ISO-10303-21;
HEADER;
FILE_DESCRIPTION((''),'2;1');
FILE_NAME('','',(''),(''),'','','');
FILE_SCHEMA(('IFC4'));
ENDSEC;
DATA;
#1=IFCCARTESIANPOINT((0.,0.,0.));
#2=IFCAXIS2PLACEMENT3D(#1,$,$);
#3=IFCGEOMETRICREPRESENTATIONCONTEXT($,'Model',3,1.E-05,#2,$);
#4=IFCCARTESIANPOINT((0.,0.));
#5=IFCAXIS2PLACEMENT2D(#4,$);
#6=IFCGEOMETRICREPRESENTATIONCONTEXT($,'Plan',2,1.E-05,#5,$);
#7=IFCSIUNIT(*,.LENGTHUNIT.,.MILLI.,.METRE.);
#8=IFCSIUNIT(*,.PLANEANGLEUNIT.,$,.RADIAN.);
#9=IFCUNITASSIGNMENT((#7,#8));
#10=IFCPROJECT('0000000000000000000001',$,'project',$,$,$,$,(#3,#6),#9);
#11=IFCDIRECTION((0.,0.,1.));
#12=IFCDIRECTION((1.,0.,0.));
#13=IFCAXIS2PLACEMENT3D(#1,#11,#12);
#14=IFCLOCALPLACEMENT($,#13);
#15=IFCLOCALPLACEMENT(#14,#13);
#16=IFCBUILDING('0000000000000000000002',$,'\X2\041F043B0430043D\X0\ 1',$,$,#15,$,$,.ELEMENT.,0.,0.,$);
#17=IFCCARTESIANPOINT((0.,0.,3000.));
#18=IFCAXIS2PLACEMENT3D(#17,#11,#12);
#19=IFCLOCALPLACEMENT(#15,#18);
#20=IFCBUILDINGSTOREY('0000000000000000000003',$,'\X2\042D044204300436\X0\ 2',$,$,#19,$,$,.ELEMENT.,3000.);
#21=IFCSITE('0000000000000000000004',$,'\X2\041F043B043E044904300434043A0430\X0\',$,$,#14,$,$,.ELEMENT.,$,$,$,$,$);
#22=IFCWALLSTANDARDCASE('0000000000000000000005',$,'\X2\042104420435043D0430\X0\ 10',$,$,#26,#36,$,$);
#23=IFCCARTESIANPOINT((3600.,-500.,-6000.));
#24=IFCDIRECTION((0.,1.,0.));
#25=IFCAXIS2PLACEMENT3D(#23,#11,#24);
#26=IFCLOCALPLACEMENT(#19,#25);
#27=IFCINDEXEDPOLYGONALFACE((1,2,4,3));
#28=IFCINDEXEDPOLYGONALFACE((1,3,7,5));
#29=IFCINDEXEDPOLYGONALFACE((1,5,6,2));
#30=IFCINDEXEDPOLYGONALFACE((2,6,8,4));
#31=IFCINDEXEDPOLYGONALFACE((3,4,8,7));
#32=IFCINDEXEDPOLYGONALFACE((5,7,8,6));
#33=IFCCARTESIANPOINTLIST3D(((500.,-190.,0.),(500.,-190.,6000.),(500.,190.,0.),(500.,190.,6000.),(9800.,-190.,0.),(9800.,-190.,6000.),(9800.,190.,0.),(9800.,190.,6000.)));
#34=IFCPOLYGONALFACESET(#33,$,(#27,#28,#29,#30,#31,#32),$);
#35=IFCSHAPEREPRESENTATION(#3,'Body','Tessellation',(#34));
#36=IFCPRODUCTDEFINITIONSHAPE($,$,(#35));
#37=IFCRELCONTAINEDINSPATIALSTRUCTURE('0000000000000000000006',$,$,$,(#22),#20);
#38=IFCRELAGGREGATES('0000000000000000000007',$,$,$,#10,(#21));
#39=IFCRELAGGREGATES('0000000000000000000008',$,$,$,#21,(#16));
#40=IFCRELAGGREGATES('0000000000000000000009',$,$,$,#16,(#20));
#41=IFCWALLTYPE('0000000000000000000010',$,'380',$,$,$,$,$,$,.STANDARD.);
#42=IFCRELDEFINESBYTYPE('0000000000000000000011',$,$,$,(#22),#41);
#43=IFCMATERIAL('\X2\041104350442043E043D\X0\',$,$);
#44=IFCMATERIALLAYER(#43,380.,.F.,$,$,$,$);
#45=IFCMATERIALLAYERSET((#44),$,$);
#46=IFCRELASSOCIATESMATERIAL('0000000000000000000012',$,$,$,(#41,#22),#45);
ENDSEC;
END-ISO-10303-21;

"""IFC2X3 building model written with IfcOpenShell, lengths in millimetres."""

from ifc_helpers import new_model, si_unit, frame, origin, origin_with_axes, origin_2d, place, context, project, spatial, polyline, segment, composite_curve, outline, extrude, material, layer, layer_set, layer_usage, type_object, element, save


model = new_model("IFC2X3")

# Units and contexts
model_context = context("Model", 3, precision=1e-05, world=origin())
plan_context = context("Plan", 2, precision=1e-05, world=origin_2d())
ifc_project = project(units=[si_unit("LENGTHUNIT", "METRE", prefix="MILLI"), si_unit("PLANEANGLEUNIT", "RADIAN")], contexts=[model_context, plan_context])

# Site, building, storey
site_placement = place(None, origin_with_axes())
site = spatial("IfcSite", under=ifc_project, at=site_placement, Name="Площадка", CompositionType="ELEMENT")
building_placement = place(site_placement, origin_with_axes())
building = spatial("IfcBuilding", under=site, at=building_placement, Name="План 1", CompositionType="ELEMENT", ElevationOfRefHeight=0.0, ElevationOfTerrain=0.0)
storey_placement = place(building_placement, frame((0.0, 0.0, 3000.0), z_axis=(0.0, 0.0, 1.0), x_axis=(1.0, 0.0, 0.0)))
storey = spatial("IfcBuildingStorey", under=building, at=storey_placement, Name="Этаж 2", CompositionType="ELEMENT", Elevation=3000.0)

# Wall
ifc_material_1 = material(Name="Бетон")
ifc_layer_1 = layer(ifc_material_1, 380.0, ventilated=False)
ifc_layer_set_1 = layer_set([ifc_layer_1])
ifc_layer_usage_1 = layer_usage(ifc_layer_set_1, "AXIS2", "POSITIVE", -190.0)
wall_type_1 = type_object("IfcWallType", Name="380", PredefinedType="STANDARD", material=ifc_layer_set_1)
wall_1_placement = place(storey_placement, frame((3600.0, -500.0, -6000.0), z_axis=(0.0, 0.0, 1.0), x_axis=(0.0, 1.0, 0.0)))
element("IfcWallStandardCase", 1, at=wall_1_placement, inside=storey, type_object=wall_type_1, material=ifc_layer_usage_1, Name="Стена 10", context=model_context, shape_type="SweptSolid", body=[
    extrude(outline(composite_curve([segment(polyline([(500.0, 190.0), (500.0, -190.0)]), True, "CONTINUOUS"), segment(polyline([(500.0, -190.0), (9800.0, -190.0)]), True, "CONTINUOUS"), segment(polyline([(9800.0, -190.0), (9800.0, 190.0)]), True, "CONTINUOUS"), segment(polyline([(9800.0, 190.0), (500.0, 190.0)]), True, "CONTINUOUS")], self_intersect=False)), origin_with_axes(), (0.0, 0.0, 1.0), 6000.0),
])

save(model, "model.ifc")
